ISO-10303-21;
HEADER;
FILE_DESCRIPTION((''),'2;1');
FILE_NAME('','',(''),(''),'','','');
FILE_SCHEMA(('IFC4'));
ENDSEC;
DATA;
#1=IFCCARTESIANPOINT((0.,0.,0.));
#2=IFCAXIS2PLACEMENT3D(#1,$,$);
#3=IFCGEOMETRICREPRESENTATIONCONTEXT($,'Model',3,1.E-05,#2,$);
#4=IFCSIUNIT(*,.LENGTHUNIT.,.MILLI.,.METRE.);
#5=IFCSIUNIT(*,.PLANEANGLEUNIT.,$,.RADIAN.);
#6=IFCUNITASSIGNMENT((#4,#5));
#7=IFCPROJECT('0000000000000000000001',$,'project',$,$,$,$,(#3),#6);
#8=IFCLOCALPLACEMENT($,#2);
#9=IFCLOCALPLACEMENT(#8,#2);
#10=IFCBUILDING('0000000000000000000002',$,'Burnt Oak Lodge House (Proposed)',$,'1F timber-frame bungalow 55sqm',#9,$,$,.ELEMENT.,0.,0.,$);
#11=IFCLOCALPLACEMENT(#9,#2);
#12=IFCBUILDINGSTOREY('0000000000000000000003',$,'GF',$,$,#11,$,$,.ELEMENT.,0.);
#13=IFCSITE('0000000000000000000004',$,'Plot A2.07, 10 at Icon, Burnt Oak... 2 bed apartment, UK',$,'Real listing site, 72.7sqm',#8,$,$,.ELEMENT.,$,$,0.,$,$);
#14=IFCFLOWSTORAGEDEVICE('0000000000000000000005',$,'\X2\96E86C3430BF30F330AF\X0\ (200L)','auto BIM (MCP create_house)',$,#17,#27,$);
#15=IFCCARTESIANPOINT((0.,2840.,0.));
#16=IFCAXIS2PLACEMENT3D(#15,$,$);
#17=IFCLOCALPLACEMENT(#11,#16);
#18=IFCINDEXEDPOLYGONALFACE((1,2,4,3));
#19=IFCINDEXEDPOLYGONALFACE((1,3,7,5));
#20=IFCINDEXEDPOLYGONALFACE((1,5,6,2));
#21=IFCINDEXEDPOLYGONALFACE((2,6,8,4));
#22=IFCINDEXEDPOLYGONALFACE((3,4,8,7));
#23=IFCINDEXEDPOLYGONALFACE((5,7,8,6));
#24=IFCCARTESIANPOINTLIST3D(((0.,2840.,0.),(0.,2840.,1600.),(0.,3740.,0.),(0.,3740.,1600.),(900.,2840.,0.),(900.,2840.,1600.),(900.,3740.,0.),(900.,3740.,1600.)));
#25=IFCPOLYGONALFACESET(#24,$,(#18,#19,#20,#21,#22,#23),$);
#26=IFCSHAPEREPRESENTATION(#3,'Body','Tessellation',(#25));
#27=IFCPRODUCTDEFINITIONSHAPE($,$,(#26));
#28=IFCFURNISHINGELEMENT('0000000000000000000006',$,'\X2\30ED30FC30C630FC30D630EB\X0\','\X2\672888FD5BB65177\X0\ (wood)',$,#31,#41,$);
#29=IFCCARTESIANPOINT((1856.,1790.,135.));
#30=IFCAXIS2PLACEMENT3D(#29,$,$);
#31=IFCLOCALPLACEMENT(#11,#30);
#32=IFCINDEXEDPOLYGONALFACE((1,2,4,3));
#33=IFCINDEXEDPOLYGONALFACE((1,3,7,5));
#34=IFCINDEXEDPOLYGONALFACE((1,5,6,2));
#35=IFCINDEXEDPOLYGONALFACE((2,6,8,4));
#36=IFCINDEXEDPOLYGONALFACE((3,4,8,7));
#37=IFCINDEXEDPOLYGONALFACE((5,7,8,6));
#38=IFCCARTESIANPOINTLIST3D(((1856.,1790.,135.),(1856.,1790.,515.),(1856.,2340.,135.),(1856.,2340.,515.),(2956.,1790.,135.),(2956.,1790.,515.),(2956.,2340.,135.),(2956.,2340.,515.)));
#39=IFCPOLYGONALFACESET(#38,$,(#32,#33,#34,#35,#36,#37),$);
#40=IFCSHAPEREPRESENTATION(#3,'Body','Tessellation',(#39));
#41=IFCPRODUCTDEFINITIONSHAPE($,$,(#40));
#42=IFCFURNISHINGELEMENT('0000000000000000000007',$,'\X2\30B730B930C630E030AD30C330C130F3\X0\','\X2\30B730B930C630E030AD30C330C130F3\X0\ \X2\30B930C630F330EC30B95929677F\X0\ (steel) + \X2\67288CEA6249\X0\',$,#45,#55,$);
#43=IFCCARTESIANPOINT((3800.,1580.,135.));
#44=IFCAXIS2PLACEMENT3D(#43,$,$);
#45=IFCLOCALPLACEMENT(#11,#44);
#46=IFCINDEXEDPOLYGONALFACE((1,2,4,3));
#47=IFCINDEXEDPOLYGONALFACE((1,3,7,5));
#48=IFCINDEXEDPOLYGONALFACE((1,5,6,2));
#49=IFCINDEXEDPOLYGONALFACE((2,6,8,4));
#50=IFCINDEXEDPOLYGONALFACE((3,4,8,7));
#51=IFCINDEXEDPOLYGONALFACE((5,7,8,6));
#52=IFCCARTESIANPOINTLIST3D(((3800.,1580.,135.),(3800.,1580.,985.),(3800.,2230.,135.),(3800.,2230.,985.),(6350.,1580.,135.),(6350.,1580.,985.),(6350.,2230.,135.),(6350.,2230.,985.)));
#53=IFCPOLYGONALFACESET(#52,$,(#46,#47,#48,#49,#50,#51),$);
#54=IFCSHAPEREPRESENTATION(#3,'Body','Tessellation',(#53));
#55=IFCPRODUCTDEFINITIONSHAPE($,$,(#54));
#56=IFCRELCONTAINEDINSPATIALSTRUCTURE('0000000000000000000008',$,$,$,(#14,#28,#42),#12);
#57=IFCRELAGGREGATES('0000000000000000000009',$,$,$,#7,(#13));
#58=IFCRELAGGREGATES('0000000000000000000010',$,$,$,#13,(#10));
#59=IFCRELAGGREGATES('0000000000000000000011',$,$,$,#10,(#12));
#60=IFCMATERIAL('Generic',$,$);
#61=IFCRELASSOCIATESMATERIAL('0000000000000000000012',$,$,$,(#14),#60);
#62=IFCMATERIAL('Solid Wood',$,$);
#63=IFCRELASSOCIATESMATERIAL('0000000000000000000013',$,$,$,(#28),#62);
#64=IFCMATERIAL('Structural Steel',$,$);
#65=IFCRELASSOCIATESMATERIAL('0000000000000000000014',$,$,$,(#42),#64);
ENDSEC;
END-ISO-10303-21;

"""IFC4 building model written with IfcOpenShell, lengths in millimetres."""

from ifc_helpers import new_model, si_unit, frame, frame_2d, origin, place, context, project, spatial, rectangle, extrude, material, element, save


model = new_model("IFC4")

# Units and contexts
model_context = context("Model", 3, precision=1e-05, world=origin())
ifc_project = project(units=[si_unit("LENGTHUNIT", "METRE", prefix="MILLI"), si_unit("PLANEANGLEUNIT", "RADIAN")], contexts=[model_context])

# Site, building, storey
site_placement = place(None, origin())
site = spatial("IfcSite", under=ifc_project, at=site_placement, Name="Plot A2.07, 10 at Icon, Burnt Oak... 2 bed apartment, UK", ObjectType="Real listing site, 72.7sqm", CompositionType="ELEMENT", RefElevation=0.0)
building_placement = place(site_placement, origin())
building = spatial("IfcBuilding", under=site, at=building_placement, Name="Burnt Oak Lodge House (Proposed)", ObjectType="1F timber-frame bungalow 55sqm", CompositionType="ELEMENT", ElevationOfRefHeight=0.0, ElevationOfTerrain=0.0)
storey_placement = place(building_placement, origin())
storey = spatial("IfcBuildingStorey", under=building, at=storey_placement, Name="GF", CompositionType="ELEMENT", Elevation=0.0)

# Shared definitions
ifc_material_1 = material(Name="Solid Wood")

# Shared definitions
ifc_material_2 = material(Name="Generic")

# Flow storage device
flow_storage_device_placement = place(storey_placement, frame((0.0, 2840.0, 0.0)))
element("IfcFlowStorageDevice", 1, at=flow_storage_device_placement, inside=storey, material=ifc_material_2, Name="雨水タンク (200L)", Description="auto BIM (MCP create_house)", context=model_context, shape_type="SweptSolid", body=[
    extrude(rectangle(XDim=900.0, YDim=900.0, at=frame_2d((450.0, 450.0))), frame((0.0, 2840.0, 0.0)), (0.0, 0.0, 1.0), 1600.0),
])

# Furnishing elements
furnishing_1_placement = place(storey_placement, frame((1856.0, 1790.0, 135.0)))
element("IfcFurnishingElement", 2, at=furnishing_1_placement, inside=storey, material=ifc_material_1, Name="ローテーブル", Description="木製家具 (wood)", context=model_context, shape_type="SweptSolid", body=[
    extrude(rectangle(XDim=1100.0, YDim=550.0, at=frame_2d((550.0, 275.0))), frame((1856.0, 1790.0, 135.0)), (0.0, 0.0, 1.0), 380.0),
])
ifc_material_3 = material(Name="Structural Steel")
furnishing_2_placement = place(storey_placement, frame((3800.0, 1580.0, 135.0)))
element("IfcFurnishingElement", 3, at=furnishing_2_placement, inside=storey, material=ifc_material_3, Name="システムキッチン", Description="システムキッチン ステンレス天板 (steel) + 木質扉", context=model_context, shape_type="SweptSolid", body=[
    extrude(rectangle(XDim=2550.0, YDim=650.0, at=frame_2d((1275.0, 325.0))), frame((3800.0, 1580.0, 135.0)), (0.0, 0.0, 1.0), 850.0),
])

save(model, "model.ifc")
